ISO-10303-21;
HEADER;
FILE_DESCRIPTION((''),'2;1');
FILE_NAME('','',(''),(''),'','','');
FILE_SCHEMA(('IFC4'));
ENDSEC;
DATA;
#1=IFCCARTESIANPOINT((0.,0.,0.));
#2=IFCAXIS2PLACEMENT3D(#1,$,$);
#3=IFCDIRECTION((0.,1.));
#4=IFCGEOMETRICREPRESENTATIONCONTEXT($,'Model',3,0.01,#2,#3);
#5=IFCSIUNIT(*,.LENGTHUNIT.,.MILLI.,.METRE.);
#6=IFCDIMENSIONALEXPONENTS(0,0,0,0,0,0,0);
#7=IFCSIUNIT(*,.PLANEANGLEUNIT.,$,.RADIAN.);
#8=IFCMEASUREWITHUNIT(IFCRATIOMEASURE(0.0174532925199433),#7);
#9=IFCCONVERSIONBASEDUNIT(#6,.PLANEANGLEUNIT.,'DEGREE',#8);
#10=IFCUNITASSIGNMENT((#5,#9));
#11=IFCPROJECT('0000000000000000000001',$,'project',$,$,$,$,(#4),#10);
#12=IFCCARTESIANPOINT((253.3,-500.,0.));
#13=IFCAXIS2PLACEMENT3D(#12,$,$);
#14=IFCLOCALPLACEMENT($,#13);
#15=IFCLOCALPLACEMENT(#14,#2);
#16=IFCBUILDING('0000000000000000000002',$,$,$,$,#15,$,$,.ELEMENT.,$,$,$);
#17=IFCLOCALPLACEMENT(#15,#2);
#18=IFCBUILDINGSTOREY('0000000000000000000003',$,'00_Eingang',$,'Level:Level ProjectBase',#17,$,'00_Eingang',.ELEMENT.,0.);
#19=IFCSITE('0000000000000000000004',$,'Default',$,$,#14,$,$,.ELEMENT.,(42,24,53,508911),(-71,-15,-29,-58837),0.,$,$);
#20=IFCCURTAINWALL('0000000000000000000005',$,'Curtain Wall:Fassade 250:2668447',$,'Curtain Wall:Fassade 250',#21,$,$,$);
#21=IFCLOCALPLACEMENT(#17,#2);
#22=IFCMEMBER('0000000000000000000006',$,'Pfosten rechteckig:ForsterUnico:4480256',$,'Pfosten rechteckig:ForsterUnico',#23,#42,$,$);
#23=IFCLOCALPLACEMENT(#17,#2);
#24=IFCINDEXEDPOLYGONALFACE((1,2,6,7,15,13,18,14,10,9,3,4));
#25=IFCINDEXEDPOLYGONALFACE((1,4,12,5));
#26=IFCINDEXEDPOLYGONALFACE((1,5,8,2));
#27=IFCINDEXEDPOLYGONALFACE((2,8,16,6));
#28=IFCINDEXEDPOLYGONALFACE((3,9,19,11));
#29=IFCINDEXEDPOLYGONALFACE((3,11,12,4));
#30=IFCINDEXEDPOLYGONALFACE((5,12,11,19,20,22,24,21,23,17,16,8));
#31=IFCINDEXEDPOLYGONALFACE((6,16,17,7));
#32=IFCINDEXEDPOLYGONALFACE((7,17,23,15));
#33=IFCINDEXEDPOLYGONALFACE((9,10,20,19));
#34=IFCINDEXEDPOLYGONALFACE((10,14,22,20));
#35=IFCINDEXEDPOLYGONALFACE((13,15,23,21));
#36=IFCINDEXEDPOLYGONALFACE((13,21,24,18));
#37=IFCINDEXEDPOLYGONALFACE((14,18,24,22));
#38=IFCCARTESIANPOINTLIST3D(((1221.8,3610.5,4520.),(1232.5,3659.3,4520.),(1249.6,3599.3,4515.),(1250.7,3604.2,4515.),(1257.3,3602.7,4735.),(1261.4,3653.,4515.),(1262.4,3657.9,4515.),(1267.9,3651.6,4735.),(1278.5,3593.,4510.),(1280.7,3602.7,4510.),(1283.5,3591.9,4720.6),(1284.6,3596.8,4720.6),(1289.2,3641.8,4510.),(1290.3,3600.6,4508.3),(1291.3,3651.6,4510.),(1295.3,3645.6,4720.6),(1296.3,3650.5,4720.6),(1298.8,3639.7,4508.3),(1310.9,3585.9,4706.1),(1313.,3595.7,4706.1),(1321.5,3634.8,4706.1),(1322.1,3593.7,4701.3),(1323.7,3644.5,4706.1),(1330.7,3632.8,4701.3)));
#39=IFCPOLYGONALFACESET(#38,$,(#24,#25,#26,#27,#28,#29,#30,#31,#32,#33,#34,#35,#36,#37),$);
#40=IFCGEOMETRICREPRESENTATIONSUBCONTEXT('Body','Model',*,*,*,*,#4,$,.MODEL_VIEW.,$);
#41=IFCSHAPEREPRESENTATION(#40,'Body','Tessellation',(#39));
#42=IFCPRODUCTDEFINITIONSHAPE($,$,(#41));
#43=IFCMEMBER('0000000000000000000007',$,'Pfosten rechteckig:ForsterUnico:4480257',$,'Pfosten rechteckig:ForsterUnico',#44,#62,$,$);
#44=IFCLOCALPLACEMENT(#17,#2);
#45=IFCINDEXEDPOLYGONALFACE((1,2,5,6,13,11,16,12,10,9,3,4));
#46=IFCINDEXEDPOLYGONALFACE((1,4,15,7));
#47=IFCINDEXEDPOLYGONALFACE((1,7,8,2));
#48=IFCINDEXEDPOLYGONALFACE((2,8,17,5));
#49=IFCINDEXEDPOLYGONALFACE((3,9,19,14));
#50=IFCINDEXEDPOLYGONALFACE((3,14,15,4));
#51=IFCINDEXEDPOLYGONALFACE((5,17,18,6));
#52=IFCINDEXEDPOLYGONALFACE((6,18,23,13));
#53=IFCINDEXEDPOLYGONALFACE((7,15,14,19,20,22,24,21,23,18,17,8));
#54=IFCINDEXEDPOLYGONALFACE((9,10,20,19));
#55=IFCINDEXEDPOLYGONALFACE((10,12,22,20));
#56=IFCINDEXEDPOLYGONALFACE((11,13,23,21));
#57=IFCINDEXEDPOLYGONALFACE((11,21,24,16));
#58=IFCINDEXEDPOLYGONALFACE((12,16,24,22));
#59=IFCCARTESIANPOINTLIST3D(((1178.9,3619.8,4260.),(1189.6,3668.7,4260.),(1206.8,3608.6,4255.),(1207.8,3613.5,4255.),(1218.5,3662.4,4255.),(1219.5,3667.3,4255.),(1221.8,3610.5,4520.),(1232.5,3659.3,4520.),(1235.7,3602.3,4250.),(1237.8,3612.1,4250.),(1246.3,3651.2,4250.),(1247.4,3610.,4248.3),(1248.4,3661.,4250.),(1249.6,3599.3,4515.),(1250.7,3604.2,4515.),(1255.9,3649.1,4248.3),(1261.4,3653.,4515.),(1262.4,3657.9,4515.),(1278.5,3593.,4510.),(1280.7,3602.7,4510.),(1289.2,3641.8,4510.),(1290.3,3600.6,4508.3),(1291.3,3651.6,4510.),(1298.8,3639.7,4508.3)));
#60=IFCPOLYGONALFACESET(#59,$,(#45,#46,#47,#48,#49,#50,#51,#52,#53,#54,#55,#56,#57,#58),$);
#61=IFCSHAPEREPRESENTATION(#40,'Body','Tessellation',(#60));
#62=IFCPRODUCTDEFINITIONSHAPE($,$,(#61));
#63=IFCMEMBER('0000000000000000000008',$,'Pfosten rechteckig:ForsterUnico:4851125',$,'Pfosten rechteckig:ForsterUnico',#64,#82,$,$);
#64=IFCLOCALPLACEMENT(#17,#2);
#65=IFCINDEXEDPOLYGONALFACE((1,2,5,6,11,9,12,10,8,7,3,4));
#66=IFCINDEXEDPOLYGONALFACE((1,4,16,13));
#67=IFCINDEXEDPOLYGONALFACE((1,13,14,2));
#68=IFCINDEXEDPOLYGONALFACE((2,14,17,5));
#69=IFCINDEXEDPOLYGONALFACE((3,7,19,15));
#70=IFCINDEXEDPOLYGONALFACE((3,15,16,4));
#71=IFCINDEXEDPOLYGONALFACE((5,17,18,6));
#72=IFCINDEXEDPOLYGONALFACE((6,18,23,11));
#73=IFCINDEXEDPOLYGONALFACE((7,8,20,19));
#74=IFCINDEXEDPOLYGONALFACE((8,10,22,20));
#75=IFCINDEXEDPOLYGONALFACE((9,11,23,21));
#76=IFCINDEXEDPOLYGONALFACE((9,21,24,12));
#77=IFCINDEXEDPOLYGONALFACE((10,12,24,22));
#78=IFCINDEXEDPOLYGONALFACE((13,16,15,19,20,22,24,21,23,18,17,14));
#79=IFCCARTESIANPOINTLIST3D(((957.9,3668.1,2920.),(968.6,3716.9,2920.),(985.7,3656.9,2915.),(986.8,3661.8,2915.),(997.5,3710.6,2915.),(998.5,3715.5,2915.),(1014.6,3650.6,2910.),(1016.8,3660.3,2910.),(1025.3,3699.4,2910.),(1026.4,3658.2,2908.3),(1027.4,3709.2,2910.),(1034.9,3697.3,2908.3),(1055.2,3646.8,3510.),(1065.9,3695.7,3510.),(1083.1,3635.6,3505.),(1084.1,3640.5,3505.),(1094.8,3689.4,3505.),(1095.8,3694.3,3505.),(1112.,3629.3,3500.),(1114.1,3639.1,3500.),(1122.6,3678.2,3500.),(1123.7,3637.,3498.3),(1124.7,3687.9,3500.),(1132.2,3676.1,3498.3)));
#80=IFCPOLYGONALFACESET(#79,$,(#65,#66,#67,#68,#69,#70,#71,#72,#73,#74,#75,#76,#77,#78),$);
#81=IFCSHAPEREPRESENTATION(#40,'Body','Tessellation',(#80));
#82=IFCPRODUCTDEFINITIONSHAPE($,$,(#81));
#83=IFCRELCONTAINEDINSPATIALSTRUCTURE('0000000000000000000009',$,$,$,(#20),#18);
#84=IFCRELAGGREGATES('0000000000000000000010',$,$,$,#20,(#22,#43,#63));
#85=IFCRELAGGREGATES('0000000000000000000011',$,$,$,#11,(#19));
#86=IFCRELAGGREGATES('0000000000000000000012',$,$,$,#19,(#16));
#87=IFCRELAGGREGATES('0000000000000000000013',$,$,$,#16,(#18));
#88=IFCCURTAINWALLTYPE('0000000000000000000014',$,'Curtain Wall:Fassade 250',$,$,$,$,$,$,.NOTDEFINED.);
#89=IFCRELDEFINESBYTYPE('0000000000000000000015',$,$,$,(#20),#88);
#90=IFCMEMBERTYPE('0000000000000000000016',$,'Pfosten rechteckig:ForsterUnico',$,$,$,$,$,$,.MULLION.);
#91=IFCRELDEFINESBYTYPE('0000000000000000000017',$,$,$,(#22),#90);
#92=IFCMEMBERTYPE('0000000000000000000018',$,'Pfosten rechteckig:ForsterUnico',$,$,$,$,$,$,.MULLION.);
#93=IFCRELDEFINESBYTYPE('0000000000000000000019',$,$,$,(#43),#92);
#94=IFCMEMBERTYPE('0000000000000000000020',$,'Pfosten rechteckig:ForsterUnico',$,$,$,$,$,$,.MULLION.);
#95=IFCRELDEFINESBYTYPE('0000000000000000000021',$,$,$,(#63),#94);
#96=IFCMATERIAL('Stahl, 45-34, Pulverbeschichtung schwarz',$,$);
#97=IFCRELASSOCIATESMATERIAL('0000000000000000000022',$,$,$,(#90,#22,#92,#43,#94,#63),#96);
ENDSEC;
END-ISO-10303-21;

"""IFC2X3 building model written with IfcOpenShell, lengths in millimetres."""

from ifc_helpers import new_model, entity, si_unit, converted_unit, direction, frame, origin, place, context, subcontext, project, spatial, polyline, outline, extrude, clip, halfspace, source, transform, mapped, material, type_object, type_shapes, element, aggregate, save


model = new_model("IFC2X3")

# Units and contexts
model_context = context("Model", 3, precision=0.01, world=origin(), true_north=direction((0.0, 1.0)))
body_context = subcontext(model_context, "Body", "Model", "MODEL_VIEW")
ifc_project = project(units=[si_unit("LENGTHUNIT", "METRE", prefix="MILLI"), converted_unit("PLANEANGLEUNIT", "DEGREE", entity("IfcRatioMeasure", 0.0174532925199433), si_unit("PLANEANGLEUNIT", "RADIAN"), dimensions=[0, 0, 0, 0, 0, 0, 0])], contexts=[model_context])

# Site, building, storey
site_placement = place(None, frame((253.3, -500.0, 0.0)))
site = spatial("IfcSite", under=ifc_project, at=site_placement, Name="Default", CompositionType="ELEMENT", RefLatitude=(42, 24, 53, 508911), RefLongitude=(-71, -15, -29, -58837), RefElevation=0.0)
building_placement = place(site_placement, origin())
building = spatial("IfcBuilding", under=site, at=building_placement, CompositionType="ELEMENT")
storey_placement = place(building_placement, origin())
storey = spatial("IfcBuildingStorey", under=building, at=storey_placement, Name="00_Eingang", ObjectType="Level:Level ProjectBase", LongName="00_Eingang", CompositionType="ELEMENT", Elevation=0.0)

# Curtain wall, members
curtain_wall_type = type_object("IfcCurtainWallType", Name="Curtain Wall:Fassade 250", PredefinedType="NOTDEFINED")
curtain_wall_placement = place(storey_placement, origin())
curtain_wall = element("IfcCurtainWall", 1, at=curtain_wall_placement, inside=storey, type_object=curtain_wall_type, Name="Curtain Wall:Fassade 250:2668447", ObjectType="Curtain Wall:Fassade 250")
ifc_material_1 = material(Name="Stahl, 45-34, Pulverbeschichtung schwarz")
member_type_1 = type_object("IfcMemberType", Name="Pfosten rechteckig:ForsterUnico", PredefinedType="MULLION", material=ifc_material_1)
shared_shape_1 = source(origin(), body_context, "Body", "Clipping", [
    clip(extrude(outline(polyline([(-20.0, -28.3), (20.0, -28.3), (20.0, -18.3), (30.0, -18.3), (30.0, 11.7), (25.0, 11.7), (25.0, 41.7), (-25.0, 41.7), (-25.0, 11.7), (-30.0, 11.7), (-30.0, -18.3), (-20.0, -18.3), (-20.0, -28.3)])), frame((-41.7, 0.0, -218.0), z_axis=(0.0, 0.0, 1.0), x_axis=(0.0, -1.0, 0.0)), (0.0, 0.0, 1.0), 218.0), halfspace(frame((0.0, -304.8, -218.0), z_axis=(-0.304182, 0.0, -0.952614), x_axis=(-0.952614, 0.0, 0.304182)), False)),
])
type_shapes(member_type_1, [shared_shape_1])
member_1_placement = place(storey_placement, frame((1227.1, 3634.9, 4520.0), z_axis=(-0.162632, 0.035489, -0.986048), x_axis=(-0.963377, 0.210226, 0.16646)))
member_1 = element("IfcMember", 2, at=member_1_placement, type_object=member_type_1, material=ifc_material_1, Name="Pfosten rechteckig:ForsterUnico:4480256", ObjectType="Pfosten rechteckig:ForsterUnico", context=body_context, shape_type="MappedRepresentation", body=[
    mapped(shared_shape_1, transform((0.0, 0.0, 0.0), scale=1.0)),
])
member_type_2 = type_object("IfcMemberType", Name="Pfosten rechteckig:ForsterUnico", PredefinedType="MULLION", material=ifc_material_1)
shared_shape_2 = source(origin(), body_context, "Body", "SweptSolid", [
    extrude(outline(polyline([(-20.0, -28.3), (20.0, -28.3), (20.0, -18.3), (30.0, -18.3), (30.0, 11.7), (25.0, 11.7), (25.0, 41.7), (-25.0, 41.7), (-25.0, 11.7), (-30.0, 11.7), (-30.0, -18.3), (-20.0, -18.3), (-20.0, -28.3)])), frame((-41.7, 0.0, -263.7), z_axis=(0.0, 0.0, 1.0), x_axis=(0.0, -1.0, 0.0)), (0.0, 0.0, 1.0), 263.7),
])
type_shapes(member_type_2, [shared_shape_2])
member_2_placement = place(storey_placement, frame((1184.2, 3644.3, 4260.0), z_axis=(-0.162632, 0.035489, -0.986048), x_axis=(-0.963377, 0.210226, 0.16646)))
member_2 = element("IfcMember", 3, at=member_2_placement, type_object=member_type_2, material=ifc_material_1, Name="Pfosten rechteckig:ForsterUnico:4480257", ObjectType="Pfosten rechteckig:ForsterUnico", context=body_context, shape_type="MappedRepresentation", body=[
    mapped(shared_shape_2, transform((0.0, 0.0, 0.0), scale=1.0)),
])
member_type_3 = type_object("IfcMemberType", Name="Pfosten rechteckig:ForsterUnico", PredefinedType="MULLION", material=ifc_material_1)
shared_shape_3 = source(origin(), body_context, "Body", "SweptSolid", [
    extrude(outline(polyline([(-20.0, -28.3), (20.0, -28.3), (20.0, -18.3), (30.0, -18.3), (30.0, 11.7), (25.0, 11.7), (25.0, 41.7), (-25.0, 41.7), (-25.0, 11.7), (-30.0, 11.7), (-30.0, -18.3), (-20.0, -18.3), (-20.0, -28.3)])), frame((-41.7, 0.0, -598.3), z_axis=(0.0, 0.0, 1.0), x_axis=(0.0, -1.0, 0.0)), (0.0, 0.0, 1.0), 598.3),
])
type_shapes(member_type_3, [shared_shape_3])
member_3_placement = place(storey_placement, frame((963.2, 3692.5, 2920.0), z_axis=(-0.162632, 0.035489, -0.986048), x_axis=(-0.963377, 0.210226, 0.16646)))
member_3 = element("IfcMember", 4, at=member_3_placement, type_object=member_type_3, material=ifc_material_1, Name="Pfosten rechteckig:ForsterUnico:4851125", ObjectType="Pfosten rechteckig:ForsterUnico", context=body_context, shape_type="MappedRepresentation", body=[
    mapped(shared_shape_3, transform((0.0, 0.0, 0.0), scale=1.0)),
])
aggregate(curtain_wall, [member_1, member_2, member_3])

save(model, "model.ifc")
